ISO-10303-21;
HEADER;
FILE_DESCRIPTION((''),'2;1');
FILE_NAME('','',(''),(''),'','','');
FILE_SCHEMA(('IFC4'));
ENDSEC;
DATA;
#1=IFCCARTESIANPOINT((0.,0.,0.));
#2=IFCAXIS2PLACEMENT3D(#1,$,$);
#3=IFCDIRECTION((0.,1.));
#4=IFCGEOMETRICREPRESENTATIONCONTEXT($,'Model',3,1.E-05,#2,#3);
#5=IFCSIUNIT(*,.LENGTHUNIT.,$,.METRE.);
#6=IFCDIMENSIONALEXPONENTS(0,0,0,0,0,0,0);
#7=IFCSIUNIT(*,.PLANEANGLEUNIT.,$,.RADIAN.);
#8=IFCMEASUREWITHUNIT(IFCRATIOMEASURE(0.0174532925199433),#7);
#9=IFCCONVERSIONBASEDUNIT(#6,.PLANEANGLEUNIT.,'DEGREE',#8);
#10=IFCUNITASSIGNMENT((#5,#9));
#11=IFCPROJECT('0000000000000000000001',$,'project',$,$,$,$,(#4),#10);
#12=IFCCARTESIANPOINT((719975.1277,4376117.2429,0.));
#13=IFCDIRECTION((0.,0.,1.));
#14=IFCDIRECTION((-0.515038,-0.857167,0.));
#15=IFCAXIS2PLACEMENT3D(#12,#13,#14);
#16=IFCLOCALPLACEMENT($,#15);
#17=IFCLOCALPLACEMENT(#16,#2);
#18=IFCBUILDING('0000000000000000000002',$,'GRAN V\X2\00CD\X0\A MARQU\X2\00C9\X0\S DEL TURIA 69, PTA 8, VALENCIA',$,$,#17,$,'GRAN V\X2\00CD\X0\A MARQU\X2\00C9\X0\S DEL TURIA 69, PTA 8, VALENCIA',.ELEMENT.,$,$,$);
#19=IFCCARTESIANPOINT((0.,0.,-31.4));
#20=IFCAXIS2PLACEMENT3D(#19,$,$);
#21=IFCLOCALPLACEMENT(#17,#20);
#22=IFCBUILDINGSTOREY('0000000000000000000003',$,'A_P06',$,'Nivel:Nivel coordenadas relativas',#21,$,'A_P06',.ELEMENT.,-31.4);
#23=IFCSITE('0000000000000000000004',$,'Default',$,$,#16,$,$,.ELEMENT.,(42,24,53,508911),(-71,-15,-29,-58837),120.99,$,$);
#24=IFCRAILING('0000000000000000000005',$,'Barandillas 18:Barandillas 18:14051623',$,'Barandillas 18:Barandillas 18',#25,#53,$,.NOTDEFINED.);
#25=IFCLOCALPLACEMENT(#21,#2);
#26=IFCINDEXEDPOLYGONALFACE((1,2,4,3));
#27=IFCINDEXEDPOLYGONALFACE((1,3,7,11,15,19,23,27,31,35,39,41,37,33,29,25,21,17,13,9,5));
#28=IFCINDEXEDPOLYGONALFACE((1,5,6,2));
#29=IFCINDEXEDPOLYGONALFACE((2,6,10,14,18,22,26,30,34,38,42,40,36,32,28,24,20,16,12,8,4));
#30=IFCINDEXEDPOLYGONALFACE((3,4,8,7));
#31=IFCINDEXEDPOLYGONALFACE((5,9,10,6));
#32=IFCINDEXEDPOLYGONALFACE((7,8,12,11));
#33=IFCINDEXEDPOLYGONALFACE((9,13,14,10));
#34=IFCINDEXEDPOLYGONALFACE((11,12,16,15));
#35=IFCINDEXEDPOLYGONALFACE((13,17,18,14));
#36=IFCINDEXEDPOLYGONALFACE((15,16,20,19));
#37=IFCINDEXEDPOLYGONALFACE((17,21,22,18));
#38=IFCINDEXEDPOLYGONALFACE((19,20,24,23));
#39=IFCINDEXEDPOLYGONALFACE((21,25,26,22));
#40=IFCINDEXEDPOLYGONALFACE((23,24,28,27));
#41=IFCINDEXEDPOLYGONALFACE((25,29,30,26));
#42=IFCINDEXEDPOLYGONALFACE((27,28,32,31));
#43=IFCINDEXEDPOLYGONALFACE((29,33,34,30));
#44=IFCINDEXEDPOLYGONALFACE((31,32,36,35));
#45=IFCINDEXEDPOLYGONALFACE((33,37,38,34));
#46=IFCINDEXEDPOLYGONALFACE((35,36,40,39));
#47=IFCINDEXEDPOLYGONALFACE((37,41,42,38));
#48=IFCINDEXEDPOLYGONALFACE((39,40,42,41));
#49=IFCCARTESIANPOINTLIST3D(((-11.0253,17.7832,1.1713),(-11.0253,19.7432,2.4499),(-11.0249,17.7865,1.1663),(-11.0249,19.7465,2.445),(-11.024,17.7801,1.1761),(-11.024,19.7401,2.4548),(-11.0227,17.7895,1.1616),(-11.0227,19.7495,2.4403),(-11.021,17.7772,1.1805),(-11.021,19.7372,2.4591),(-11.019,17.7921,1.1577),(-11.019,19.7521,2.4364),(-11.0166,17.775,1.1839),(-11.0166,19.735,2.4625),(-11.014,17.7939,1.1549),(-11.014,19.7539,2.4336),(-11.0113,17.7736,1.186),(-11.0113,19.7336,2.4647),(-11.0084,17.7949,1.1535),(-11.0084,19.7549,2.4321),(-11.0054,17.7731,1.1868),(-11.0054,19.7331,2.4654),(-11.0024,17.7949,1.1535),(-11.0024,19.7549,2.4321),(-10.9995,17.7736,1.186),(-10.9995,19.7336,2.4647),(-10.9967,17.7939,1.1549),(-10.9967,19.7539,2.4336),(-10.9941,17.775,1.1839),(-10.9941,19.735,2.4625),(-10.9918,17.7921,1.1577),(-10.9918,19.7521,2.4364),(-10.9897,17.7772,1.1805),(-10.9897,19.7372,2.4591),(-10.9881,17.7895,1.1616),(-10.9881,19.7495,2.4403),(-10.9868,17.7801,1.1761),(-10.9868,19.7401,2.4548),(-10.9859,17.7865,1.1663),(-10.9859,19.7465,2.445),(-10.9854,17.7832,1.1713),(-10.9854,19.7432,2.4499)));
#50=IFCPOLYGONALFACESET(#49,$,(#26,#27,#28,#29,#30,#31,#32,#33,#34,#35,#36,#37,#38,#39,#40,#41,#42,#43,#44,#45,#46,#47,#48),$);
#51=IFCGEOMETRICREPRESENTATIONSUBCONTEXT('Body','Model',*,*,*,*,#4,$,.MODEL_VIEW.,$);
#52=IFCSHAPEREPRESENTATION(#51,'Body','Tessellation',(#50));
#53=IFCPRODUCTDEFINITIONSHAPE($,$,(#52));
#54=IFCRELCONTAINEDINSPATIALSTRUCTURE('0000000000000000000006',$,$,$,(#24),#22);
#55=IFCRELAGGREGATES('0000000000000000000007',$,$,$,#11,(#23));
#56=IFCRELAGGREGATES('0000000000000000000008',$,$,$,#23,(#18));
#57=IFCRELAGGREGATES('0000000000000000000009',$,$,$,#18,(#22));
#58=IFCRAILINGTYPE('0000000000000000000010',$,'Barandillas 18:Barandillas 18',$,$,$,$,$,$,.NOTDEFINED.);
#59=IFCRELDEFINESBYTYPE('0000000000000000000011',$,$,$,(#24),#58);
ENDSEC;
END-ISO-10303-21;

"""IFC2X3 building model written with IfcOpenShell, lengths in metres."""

from ifc_helpers import new_model, entity, si_unit, converted_unit, direction, frame, origin, origin_2d_with_axis, place, context, subcontext, project, spatial, circle, extrude, source, transform, mapped, type_object, type_shapes, element, save


model = new_model("IFC2X3")

# Units and contexts
model_context = context("Model", 3, precision=1e-05, world=origin(), true_north=direction((0.0, 1.0)))
body_context = subcontext(model_context, "Body", "Model", "MODEL_VIEW")
ifc_project = project(units=[si_unit("LENGTHUNIT", "METRE"), converted_unit("PLANEANGLEUNIT", "DEGREE", entity("IfcRatioMeasure", 0.0174532925199433), si_unit("PLANEANGLEUNIT", "RADIAN"), dimensions=[0, 0, 0, 0, 0, 0, 0])], contexts=[model_context])

# Site, building, storey
site_placement = place(None, frame((719975.1277, 4376117.2429, 0.0), z_axis=(0.0, 0.0, 1.0), x_axis=(-0.515038, -0.857167, 0.0)))
site = spatial("IfcSite", under=ifc_project, at=site_placement, Name="Default", CompositionType="ELEMENT", RefLatitude=(42, 24, 53, 508911), RefLongitude=(-71, -15, -29, -58837), RefElevation=120.99)
building_placement = place(site_placement, origin())
building = spatial("IfcBuilding", under=site, at=building_placement, Name="GRAN VÍA MARQUÉS DEL TURIA 69, PTA 8, VALENCIA", LongName="GRAN VÍA MARQUÉS DEL TURIA 69, PTA 8, VALENCIA", CompositionType="ELEMENT")
storey_placement = place(building_placement, frame((0.0, 0.0, -31.4)))
storey = spatial("IfcBuildingStorey", under=building, at=storey_placement, Name="A_P06", ObjectType="Nivel:Nivel coordenadas relativas", LongName="A_P06", CompositionType="ELEMENT", Elevation=-31.4)

# Railing
railing_type = type_object("IfcRailingType", Name="Barandillas 18:Barandillas 18", PredefinedType="NOTDEFINED")
shared_shape_1 = source(origin(), body_context, "Body", "SweptSolid", [
    extrude(circle(Radius=0.02, at=origin_2d_with_axis()), frame((-11.0054, 17.7841, -33.18), z_axis=(0.0, 0.837533, 0.546387), x_axis=(0.0, -0.546387, 0.837533)), (0.0, 0.0, 1.0), 2.3402),
])
type_shapes(railing_type, [shared_shape_1])
railing_placement = place(storey_placement, frame((0.0, 0.0, 34.35)))
element("IfcRailing", 1, at=railing_placement, inside=storey, type_object=railing_type, Name="Barandillas 18:Barandillas 18:14051623", ObjectType="Barandillas 18:Barandillas 18", PredefinedType="NOTDEFINED", context=body_context, shape_type="MappedRepresentation", body=[
    mapped(shared_shape_1, transform((0.0, 0.0, 0.0), scale=1.0)),
])

save(model, "model.ifc")
